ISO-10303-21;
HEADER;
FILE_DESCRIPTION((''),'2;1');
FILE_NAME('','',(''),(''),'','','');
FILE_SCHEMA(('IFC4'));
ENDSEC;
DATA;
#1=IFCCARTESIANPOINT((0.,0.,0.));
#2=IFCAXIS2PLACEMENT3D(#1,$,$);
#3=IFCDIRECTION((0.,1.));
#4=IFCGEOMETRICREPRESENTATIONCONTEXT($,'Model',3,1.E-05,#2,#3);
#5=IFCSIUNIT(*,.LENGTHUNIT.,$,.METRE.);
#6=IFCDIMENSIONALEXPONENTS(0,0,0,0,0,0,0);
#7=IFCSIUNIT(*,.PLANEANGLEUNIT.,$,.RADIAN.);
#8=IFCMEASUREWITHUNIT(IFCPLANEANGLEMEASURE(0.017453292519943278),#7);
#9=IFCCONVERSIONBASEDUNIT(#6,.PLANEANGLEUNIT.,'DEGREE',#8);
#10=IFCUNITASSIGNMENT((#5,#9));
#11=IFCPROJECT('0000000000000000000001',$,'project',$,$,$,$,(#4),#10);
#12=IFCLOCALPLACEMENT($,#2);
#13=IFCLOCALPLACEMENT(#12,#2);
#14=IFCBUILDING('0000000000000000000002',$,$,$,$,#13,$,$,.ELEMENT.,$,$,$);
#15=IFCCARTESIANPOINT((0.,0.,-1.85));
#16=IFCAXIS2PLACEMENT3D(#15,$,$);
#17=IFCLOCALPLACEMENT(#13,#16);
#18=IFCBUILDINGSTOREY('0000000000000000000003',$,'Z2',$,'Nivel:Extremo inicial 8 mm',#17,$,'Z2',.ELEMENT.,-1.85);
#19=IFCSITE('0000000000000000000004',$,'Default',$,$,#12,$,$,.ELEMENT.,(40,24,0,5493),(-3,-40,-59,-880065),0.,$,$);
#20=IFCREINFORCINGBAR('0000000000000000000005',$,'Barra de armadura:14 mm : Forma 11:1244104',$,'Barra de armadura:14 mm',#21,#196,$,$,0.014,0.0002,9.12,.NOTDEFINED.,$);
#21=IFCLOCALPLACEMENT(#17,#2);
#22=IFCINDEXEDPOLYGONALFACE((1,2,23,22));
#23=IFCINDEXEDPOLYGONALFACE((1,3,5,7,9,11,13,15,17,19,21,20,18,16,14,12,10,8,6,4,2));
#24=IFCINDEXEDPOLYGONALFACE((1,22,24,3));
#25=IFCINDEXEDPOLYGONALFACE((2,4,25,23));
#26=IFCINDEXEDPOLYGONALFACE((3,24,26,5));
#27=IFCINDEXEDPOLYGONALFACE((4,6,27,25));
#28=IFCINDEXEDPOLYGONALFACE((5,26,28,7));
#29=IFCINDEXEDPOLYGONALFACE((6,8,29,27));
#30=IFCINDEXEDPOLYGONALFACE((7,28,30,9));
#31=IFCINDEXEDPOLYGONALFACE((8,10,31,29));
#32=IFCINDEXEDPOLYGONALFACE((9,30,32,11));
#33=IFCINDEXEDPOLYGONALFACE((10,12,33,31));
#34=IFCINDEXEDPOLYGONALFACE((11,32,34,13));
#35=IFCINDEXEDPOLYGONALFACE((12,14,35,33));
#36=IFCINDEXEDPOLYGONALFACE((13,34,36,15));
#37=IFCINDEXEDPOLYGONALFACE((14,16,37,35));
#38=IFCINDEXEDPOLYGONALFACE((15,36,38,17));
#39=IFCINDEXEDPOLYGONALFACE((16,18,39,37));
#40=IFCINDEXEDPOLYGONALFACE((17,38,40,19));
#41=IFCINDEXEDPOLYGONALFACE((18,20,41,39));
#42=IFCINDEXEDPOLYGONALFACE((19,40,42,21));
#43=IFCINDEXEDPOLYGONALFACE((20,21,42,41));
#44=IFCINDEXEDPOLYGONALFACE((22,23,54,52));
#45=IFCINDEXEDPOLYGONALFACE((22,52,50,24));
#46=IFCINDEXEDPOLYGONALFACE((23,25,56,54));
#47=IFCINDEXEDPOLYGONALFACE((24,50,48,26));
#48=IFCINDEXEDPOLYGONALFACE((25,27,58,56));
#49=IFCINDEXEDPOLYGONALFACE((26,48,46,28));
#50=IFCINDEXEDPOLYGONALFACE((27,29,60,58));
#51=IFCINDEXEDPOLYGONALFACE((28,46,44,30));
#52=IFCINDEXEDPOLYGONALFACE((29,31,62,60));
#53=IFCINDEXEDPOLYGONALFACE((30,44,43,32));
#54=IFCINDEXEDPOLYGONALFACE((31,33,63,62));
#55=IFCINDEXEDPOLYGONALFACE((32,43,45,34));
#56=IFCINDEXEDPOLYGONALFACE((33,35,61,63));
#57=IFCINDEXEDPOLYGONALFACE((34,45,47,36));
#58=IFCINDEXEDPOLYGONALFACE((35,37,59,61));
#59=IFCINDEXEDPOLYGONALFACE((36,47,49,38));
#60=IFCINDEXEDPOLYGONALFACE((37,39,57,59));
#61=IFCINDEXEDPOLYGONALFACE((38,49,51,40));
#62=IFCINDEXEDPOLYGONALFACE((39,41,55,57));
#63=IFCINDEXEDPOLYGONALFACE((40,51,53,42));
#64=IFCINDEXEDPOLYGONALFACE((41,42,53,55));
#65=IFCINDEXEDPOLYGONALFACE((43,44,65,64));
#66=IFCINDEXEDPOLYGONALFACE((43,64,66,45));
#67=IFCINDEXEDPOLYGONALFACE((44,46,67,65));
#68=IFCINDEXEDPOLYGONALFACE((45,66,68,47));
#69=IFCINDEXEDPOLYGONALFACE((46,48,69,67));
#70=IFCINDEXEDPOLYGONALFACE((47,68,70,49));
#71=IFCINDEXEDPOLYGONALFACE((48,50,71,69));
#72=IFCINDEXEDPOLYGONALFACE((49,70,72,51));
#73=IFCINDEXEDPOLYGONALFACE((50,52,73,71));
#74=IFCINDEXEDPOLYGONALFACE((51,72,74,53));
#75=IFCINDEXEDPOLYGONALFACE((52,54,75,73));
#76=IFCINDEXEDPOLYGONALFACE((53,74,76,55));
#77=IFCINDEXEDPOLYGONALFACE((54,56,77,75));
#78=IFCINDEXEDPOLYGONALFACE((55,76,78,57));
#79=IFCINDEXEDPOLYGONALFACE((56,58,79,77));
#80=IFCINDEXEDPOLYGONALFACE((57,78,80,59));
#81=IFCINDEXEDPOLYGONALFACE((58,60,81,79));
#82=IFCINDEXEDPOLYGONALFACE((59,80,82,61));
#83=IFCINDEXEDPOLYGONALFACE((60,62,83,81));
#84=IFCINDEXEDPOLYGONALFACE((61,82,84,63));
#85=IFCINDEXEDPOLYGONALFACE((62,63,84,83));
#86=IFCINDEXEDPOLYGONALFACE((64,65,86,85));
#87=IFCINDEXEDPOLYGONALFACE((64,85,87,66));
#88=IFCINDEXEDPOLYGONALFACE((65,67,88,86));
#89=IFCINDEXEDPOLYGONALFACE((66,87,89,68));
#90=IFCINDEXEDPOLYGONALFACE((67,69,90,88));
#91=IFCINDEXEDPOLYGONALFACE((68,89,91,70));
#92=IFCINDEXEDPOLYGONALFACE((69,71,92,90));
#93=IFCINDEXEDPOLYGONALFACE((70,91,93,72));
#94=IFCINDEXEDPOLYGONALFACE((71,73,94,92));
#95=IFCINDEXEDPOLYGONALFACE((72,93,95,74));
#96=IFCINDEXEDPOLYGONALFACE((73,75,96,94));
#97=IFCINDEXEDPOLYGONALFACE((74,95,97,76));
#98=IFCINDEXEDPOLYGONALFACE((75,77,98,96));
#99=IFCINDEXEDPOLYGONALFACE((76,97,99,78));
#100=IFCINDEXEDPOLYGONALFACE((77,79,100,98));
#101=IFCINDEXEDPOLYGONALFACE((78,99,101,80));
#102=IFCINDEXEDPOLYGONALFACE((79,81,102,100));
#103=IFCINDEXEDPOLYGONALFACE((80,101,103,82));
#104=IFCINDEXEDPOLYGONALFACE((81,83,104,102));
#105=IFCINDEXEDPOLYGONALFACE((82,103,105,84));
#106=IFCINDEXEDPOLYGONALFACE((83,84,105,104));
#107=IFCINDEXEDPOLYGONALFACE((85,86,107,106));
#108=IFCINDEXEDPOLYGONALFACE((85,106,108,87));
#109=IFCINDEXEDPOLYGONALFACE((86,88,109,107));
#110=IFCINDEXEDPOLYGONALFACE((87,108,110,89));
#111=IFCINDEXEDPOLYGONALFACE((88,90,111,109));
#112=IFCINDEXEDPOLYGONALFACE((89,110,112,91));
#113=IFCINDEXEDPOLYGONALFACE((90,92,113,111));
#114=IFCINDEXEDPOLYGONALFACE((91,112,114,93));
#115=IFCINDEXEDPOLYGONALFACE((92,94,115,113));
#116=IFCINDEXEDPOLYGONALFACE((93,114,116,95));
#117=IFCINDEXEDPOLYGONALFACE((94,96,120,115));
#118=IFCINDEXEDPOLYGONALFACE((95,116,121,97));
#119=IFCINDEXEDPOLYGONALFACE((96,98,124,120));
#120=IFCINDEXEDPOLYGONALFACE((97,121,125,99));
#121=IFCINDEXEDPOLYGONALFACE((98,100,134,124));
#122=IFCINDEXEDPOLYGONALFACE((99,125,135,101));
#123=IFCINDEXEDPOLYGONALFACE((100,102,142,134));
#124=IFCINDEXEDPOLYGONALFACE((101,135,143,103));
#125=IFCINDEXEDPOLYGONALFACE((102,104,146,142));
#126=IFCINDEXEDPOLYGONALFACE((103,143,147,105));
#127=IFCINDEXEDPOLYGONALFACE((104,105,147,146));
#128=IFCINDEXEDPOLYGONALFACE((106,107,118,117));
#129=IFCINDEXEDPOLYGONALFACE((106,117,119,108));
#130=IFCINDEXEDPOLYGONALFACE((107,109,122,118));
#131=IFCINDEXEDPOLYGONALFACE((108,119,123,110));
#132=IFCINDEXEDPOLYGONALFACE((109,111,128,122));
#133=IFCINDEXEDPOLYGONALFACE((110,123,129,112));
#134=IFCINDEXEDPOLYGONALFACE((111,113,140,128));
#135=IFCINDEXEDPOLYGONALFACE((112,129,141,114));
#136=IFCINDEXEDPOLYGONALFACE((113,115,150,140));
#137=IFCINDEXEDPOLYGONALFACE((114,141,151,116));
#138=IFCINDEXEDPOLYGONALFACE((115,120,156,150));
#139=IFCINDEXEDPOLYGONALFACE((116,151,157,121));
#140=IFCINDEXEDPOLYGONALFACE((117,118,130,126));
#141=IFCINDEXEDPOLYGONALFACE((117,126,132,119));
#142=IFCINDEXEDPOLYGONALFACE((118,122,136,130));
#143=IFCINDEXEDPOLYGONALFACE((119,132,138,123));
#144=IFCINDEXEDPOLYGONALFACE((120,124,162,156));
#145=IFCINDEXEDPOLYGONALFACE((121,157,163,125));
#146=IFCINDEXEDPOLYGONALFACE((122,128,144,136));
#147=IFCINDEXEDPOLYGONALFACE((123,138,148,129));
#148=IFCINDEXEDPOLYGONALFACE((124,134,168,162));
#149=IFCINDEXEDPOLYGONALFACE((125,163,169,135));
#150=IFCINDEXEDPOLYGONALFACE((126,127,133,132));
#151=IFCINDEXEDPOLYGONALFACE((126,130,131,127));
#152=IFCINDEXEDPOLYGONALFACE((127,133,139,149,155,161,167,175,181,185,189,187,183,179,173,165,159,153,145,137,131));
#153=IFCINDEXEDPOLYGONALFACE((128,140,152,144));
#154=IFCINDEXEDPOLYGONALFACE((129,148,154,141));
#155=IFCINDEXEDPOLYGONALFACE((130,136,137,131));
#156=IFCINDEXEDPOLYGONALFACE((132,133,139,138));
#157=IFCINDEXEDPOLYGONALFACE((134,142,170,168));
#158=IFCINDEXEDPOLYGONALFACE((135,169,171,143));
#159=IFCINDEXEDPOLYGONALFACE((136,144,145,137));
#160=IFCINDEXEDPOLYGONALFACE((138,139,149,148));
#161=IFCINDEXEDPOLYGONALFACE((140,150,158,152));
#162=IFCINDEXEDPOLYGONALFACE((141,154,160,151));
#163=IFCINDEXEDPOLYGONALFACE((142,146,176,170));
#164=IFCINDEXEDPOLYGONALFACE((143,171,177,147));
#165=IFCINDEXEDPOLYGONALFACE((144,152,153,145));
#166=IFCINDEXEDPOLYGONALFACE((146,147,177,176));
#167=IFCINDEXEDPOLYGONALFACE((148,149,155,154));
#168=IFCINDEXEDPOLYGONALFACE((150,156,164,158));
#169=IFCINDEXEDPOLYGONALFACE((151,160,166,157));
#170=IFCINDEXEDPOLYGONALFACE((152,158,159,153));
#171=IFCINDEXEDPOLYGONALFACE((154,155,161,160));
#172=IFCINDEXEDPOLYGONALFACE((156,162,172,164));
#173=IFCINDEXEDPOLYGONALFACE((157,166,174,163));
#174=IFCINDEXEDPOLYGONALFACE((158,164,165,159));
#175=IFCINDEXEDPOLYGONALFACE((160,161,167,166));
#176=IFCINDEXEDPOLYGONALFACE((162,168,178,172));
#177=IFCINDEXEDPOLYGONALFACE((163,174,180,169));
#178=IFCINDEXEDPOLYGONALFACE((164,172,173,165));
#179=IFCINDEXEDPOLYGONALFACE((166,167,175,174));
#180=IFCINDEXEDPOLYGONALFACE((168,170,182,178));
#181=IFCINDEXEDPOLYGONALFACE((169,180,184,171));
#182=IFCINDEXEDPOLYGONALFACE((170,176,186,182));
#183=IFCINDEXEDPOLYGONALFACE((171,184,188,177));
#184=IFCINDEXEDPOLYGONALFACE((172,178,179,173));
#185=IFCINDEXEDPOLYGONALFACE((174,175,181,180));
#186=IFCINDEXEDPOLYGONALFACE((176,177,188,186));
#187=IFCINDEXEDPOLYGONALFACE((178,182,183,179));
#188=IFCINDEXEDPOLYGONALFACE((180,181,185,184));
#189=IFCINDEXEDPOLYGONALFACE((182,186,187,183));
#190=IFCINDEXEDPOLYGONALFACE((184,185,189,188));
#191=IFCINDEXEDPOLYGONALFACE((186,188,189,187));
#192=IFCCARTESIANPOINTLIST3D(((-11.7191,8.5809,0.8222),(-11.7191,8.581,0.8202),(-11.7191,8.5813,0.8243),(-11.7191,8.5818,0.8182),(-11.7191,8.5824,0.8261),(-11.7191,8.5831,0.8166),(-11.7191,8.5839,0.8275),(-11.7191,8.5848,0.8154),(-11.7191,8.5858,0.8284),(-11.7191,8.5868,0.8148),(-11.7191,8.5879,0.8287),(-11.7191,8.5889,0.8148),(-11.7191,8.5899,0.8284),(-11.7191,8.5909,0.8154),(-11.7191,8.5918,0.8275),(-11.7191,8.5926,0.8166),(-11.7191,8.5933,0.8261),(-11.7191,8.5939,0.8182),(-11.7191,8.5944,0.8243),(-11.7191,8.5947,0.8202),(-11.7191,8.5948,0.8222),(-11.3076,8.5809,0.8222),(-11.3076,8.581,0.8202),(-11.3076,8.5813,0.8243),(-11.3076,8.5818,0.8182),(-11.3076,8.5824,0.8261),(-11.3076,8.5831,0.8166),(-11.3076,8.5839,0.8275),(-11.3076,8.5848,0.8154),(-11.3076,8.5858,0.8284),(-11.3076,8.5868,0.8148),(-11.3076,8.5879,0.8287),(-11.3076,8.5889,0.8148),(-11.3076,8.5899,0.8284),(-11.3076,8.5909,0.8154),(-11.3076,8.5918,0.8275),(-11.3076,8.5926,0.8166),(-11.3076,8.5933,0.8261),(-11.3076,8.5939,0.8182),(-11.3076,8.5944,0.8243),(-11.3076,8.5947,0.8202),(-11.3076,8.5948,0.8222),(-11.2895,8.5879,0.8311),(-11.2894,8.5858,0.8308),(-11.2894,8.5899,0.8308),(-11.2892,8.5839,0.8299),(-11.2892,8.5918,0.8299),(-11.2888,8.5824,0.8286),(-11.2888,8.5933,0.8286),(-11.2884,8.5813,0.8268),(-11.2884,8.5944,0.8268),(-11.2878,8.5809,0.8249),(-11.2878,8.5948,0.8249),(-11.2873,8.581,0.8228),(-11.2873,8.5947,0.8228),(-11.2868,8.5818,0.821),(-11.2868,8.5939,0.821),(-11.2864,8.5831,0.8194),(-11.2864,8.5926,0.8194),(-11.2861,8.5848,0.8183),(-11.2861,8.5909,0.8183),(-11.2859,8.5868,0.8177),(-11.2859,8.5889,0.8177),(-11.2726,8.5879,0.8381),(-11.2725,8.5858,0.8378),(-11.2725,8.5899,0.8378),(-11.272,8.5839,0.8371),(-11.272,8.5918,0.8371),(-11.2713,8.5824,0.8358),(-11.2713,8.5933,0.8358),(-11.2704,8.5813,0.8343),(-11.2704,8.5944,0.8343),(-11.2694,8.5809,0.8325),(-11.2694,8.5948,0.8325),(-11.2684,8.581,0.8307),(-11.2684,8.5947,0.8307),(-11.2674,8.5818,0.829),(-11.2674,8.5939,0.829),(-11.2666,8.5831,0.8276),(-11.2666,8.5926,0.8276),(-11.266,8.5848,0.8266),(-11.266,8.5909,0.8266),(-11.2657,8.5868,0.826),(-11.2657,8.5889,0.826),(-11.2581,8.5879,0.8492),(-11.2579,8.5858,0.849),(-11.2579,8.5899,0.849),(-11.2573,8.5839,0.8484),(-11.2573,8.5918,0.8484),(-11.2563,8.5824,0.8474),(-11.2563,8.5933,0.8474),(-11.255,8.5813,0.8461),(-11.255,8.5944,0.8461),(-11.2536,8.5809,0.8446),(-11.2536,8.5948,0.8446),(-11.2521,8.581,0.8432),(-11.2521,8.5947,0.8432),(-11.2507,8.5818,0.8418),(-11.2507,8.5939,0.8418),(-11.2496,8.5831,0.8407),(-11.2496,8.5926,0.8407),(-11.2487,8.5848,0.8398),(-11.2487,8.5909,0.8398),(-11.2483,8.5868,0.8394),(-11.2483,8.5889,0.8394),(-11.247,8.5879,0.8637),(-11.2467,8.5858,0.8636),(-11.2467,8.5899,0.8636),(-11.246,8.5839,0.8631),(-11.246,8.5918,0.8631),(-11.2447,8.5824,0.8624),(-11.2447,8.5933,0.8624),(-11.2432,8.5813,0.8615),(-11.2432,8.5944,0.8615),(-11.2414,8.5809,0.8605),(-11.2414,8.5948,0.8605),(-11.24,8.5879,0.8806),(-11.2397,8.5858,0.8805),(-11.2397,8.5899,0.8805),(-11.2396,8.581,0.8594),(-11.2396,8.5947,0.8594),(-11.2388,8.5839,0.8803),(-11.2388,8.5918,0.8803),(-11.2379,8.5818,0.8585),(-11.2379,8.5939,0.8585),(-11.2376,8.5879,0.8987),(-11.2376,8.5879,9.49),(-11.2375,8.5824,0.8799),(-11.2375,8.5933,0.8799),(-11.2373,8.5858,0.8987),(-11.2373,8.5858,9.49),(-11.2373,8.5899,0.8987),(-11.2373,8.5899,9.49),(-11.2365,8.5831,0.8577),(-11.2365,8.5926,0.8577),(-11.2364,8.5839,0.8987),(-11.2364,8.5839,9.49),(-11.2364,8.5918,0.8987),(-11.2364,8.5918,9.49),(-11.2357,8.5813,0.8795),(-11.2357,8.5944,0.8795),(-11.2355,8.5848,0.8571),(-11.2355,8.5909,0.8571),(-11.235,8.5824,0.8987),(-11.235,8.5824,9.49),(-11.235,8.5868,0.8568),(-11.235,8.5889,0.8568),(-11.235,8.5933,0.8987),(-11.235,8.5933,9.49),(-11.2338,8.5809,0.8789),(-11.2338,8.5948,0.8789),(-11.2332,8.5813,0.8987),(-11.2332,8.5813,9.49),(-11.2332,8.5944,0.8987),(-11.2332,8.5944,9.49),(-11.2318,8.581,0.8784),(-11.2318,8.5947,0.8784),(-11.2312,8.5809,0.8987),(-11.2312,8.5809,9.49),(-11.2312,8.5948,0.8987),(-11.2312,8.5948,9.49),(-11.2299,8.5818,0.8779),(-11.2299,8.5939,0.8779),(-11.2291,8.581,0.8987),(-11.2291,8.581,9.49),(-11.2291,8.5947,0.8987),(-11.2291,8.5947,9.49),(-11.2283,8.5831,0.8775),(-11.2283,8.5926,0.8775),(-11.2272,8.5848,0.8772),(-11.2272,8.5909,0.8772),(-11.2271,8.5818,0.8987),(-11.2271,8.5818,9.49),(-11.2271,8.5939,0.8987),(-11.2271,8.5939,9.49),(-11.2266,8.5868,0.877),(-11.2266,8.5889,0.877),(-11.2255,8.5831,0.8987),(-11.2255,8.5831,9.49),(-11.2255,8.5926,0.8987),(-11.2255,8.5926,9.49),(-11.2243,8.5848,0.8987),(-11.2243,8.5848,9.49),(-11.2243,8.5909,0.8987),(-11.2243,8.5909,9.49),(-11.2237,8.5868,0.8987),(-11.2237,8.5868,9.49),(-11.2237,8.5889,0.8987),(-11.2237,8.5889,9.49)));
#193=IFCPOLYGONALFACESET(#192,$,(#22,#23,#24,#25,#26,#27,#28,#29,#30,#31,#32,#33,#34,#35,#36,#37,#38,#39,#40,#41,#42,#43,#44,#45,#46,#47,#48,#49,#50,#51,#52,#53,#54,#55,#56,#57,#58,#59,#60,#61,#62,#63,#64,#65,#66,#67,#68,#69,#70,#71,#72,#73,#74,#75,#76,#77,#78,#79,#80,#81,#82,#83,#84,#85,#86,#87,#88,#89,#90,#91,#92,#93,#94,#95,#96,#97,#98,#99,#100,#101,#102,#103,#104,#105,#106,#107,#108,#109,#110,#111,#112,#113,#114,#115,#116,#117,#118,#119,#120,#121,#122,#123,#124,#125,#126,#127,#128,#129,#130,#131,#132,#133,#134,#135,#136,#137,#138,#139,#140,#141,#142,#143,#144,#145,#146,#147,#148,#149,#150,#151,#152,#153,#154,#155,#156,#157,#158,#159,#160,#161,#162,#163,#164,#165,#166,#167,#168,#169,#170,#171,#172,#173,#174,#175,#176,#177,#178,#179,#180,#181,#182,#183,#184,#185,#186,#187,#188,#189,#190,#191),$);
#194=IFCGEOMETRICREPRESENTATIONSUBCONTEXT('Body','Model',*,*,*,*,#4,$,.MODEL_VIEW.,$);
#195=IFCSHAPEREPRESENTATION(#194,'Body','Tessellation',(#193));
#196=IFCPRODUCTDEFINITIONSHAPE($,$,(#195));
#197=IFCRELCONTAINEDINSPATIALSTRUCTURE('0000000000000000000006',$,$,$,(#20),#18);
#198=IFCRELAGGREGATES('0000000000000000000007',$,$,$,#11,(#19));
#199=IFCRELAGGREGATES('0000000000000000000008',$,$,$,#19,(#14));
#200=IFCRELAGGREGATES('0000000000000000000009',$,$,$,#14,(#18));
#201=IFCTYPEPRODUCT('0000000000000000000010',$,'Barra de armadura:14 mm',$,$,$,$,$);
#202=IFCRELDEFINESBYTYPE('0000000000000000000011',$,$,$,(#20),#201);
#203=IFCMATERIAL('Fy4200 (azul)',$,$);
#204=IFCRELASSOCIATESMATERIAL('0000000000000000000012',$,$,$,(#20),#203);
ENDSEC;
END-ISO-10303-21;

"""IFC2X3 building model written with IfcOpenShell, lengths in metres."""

from ifc_helpers import new_model, entity, si_unit, converted_unit, direction, frame, origin, place, context, subcontext, project, spatial, material, type_object, element, save


model = new_model("IFC2X3")

# Units and contexts
model_context = context("Model", 3, precision=1e-05, world=origin(), true_north=direction((0.0, 1.0)))
body_context = subcontext(model_context, "Body", "Model", "MODEL_VIEW")
ifc_project = project(units=[si_unit("LENGTHUNIT", "METRE"), converted_unit("PLANEANGLEUNIT", "DEGREE", entity("IfcPlaneAngleMeasure", 0.017453292519943278), si_unit("PLANEANGLEUNIT", "RADIAN"), dimensions=[0, 0, 0, 0, 0, 0, 0])], contexts=[model_context])

# Site, building, storey
site_placement = place(None, origin())
site = spatial("IfcSite", under=ifc_project, at=site_placement, Name="Default", CompositionType="ELEMENT", RefLatitude=(40, 24, 0, 5493), RefLongitude=(-3, -40, -59, -880065), RefElevation=0.0)
building_placement = place(site_placement, origin())
building = spatial("IfcBuilding", under=site, at=building_placement, CompositionType="ELEMENT")
storey_placement = place(building_placement, frame((0.0, 0.0, -1.85)))
storey = spatial("IfcBuildingStorey", under=building, at=storey_placement, Name="Z2", ObjectType="Nivel:Extremo inicial 8 mm", LongName="Z2", CompositionType="ELEMENT", Elevation=-1.85)

# Reinforcing bar
ifc_material_1 = material(Name="Fy4200 (azul)")
type_product_1 = type_object("IfcTypeProduct", Name="Barra de armadura:14 mm")
reinforcing_bar_1_placement = place(storey_placement, origin())
element("IfcReinforcingBar", 1, at=reinforcing_bar_1_placement, inside=storey, type_object=type_product_1, material=ifc_material_1, Name="Barra de armadura:14 mm : Forma 11:1244104", ObjectType="Barra de armadura:14 mm", BarLength=9.12, BarRole="NOTDEFINED", CrossSectionArea=0.0002, NominalDiameter=0.014, context=body_context, shape_type="AdvancedSweptSolid", body=[
    entity("IfcSweptDiskSolid", entity("IfcCompositeCurve", [entity("IfcCompositeCurveSegment", "CONTINUOUS", True, entity("IfcPolyline", [entity("IfcCartesianPoint", [-11.2306, 8.5879, 9.49]), entity("IfcCartesianPoint", [-11.2306, 8.5879, 0.8987])])), entity("IfcCompositeCurveSegment", "CONTINUOUS", True, entity("IfcTrimmedCurve", entity("IfcCircle", entity("IfcAxis2Placement3D", entity("IfcCartesianPoint", [-11.3076, 8.5879, 0.8987]), entity("IfcDirection", [0.0, 1.0, 0.0]), entity("IfcDirection", [0.0, 0.0, -1.0])), 0.077), [entity("IfcParameterValue", 270.0)], [entity("IfcParameterValue", 360.0)], True, "PARAMETER")), entity("IfcCompositeCurveSegment", "CONTINUOUS", True, entity("IfcPolyline", [entity("IfcCartesianPoint", [-11.3076, 8.5879, 0.8217]), entity("IfcCartesianPoint", [-11.7191, 8.5879, 0.8217])]))], False), 0.007, None, 0.0, 92.0),
])

save(model, "model.ifc")
